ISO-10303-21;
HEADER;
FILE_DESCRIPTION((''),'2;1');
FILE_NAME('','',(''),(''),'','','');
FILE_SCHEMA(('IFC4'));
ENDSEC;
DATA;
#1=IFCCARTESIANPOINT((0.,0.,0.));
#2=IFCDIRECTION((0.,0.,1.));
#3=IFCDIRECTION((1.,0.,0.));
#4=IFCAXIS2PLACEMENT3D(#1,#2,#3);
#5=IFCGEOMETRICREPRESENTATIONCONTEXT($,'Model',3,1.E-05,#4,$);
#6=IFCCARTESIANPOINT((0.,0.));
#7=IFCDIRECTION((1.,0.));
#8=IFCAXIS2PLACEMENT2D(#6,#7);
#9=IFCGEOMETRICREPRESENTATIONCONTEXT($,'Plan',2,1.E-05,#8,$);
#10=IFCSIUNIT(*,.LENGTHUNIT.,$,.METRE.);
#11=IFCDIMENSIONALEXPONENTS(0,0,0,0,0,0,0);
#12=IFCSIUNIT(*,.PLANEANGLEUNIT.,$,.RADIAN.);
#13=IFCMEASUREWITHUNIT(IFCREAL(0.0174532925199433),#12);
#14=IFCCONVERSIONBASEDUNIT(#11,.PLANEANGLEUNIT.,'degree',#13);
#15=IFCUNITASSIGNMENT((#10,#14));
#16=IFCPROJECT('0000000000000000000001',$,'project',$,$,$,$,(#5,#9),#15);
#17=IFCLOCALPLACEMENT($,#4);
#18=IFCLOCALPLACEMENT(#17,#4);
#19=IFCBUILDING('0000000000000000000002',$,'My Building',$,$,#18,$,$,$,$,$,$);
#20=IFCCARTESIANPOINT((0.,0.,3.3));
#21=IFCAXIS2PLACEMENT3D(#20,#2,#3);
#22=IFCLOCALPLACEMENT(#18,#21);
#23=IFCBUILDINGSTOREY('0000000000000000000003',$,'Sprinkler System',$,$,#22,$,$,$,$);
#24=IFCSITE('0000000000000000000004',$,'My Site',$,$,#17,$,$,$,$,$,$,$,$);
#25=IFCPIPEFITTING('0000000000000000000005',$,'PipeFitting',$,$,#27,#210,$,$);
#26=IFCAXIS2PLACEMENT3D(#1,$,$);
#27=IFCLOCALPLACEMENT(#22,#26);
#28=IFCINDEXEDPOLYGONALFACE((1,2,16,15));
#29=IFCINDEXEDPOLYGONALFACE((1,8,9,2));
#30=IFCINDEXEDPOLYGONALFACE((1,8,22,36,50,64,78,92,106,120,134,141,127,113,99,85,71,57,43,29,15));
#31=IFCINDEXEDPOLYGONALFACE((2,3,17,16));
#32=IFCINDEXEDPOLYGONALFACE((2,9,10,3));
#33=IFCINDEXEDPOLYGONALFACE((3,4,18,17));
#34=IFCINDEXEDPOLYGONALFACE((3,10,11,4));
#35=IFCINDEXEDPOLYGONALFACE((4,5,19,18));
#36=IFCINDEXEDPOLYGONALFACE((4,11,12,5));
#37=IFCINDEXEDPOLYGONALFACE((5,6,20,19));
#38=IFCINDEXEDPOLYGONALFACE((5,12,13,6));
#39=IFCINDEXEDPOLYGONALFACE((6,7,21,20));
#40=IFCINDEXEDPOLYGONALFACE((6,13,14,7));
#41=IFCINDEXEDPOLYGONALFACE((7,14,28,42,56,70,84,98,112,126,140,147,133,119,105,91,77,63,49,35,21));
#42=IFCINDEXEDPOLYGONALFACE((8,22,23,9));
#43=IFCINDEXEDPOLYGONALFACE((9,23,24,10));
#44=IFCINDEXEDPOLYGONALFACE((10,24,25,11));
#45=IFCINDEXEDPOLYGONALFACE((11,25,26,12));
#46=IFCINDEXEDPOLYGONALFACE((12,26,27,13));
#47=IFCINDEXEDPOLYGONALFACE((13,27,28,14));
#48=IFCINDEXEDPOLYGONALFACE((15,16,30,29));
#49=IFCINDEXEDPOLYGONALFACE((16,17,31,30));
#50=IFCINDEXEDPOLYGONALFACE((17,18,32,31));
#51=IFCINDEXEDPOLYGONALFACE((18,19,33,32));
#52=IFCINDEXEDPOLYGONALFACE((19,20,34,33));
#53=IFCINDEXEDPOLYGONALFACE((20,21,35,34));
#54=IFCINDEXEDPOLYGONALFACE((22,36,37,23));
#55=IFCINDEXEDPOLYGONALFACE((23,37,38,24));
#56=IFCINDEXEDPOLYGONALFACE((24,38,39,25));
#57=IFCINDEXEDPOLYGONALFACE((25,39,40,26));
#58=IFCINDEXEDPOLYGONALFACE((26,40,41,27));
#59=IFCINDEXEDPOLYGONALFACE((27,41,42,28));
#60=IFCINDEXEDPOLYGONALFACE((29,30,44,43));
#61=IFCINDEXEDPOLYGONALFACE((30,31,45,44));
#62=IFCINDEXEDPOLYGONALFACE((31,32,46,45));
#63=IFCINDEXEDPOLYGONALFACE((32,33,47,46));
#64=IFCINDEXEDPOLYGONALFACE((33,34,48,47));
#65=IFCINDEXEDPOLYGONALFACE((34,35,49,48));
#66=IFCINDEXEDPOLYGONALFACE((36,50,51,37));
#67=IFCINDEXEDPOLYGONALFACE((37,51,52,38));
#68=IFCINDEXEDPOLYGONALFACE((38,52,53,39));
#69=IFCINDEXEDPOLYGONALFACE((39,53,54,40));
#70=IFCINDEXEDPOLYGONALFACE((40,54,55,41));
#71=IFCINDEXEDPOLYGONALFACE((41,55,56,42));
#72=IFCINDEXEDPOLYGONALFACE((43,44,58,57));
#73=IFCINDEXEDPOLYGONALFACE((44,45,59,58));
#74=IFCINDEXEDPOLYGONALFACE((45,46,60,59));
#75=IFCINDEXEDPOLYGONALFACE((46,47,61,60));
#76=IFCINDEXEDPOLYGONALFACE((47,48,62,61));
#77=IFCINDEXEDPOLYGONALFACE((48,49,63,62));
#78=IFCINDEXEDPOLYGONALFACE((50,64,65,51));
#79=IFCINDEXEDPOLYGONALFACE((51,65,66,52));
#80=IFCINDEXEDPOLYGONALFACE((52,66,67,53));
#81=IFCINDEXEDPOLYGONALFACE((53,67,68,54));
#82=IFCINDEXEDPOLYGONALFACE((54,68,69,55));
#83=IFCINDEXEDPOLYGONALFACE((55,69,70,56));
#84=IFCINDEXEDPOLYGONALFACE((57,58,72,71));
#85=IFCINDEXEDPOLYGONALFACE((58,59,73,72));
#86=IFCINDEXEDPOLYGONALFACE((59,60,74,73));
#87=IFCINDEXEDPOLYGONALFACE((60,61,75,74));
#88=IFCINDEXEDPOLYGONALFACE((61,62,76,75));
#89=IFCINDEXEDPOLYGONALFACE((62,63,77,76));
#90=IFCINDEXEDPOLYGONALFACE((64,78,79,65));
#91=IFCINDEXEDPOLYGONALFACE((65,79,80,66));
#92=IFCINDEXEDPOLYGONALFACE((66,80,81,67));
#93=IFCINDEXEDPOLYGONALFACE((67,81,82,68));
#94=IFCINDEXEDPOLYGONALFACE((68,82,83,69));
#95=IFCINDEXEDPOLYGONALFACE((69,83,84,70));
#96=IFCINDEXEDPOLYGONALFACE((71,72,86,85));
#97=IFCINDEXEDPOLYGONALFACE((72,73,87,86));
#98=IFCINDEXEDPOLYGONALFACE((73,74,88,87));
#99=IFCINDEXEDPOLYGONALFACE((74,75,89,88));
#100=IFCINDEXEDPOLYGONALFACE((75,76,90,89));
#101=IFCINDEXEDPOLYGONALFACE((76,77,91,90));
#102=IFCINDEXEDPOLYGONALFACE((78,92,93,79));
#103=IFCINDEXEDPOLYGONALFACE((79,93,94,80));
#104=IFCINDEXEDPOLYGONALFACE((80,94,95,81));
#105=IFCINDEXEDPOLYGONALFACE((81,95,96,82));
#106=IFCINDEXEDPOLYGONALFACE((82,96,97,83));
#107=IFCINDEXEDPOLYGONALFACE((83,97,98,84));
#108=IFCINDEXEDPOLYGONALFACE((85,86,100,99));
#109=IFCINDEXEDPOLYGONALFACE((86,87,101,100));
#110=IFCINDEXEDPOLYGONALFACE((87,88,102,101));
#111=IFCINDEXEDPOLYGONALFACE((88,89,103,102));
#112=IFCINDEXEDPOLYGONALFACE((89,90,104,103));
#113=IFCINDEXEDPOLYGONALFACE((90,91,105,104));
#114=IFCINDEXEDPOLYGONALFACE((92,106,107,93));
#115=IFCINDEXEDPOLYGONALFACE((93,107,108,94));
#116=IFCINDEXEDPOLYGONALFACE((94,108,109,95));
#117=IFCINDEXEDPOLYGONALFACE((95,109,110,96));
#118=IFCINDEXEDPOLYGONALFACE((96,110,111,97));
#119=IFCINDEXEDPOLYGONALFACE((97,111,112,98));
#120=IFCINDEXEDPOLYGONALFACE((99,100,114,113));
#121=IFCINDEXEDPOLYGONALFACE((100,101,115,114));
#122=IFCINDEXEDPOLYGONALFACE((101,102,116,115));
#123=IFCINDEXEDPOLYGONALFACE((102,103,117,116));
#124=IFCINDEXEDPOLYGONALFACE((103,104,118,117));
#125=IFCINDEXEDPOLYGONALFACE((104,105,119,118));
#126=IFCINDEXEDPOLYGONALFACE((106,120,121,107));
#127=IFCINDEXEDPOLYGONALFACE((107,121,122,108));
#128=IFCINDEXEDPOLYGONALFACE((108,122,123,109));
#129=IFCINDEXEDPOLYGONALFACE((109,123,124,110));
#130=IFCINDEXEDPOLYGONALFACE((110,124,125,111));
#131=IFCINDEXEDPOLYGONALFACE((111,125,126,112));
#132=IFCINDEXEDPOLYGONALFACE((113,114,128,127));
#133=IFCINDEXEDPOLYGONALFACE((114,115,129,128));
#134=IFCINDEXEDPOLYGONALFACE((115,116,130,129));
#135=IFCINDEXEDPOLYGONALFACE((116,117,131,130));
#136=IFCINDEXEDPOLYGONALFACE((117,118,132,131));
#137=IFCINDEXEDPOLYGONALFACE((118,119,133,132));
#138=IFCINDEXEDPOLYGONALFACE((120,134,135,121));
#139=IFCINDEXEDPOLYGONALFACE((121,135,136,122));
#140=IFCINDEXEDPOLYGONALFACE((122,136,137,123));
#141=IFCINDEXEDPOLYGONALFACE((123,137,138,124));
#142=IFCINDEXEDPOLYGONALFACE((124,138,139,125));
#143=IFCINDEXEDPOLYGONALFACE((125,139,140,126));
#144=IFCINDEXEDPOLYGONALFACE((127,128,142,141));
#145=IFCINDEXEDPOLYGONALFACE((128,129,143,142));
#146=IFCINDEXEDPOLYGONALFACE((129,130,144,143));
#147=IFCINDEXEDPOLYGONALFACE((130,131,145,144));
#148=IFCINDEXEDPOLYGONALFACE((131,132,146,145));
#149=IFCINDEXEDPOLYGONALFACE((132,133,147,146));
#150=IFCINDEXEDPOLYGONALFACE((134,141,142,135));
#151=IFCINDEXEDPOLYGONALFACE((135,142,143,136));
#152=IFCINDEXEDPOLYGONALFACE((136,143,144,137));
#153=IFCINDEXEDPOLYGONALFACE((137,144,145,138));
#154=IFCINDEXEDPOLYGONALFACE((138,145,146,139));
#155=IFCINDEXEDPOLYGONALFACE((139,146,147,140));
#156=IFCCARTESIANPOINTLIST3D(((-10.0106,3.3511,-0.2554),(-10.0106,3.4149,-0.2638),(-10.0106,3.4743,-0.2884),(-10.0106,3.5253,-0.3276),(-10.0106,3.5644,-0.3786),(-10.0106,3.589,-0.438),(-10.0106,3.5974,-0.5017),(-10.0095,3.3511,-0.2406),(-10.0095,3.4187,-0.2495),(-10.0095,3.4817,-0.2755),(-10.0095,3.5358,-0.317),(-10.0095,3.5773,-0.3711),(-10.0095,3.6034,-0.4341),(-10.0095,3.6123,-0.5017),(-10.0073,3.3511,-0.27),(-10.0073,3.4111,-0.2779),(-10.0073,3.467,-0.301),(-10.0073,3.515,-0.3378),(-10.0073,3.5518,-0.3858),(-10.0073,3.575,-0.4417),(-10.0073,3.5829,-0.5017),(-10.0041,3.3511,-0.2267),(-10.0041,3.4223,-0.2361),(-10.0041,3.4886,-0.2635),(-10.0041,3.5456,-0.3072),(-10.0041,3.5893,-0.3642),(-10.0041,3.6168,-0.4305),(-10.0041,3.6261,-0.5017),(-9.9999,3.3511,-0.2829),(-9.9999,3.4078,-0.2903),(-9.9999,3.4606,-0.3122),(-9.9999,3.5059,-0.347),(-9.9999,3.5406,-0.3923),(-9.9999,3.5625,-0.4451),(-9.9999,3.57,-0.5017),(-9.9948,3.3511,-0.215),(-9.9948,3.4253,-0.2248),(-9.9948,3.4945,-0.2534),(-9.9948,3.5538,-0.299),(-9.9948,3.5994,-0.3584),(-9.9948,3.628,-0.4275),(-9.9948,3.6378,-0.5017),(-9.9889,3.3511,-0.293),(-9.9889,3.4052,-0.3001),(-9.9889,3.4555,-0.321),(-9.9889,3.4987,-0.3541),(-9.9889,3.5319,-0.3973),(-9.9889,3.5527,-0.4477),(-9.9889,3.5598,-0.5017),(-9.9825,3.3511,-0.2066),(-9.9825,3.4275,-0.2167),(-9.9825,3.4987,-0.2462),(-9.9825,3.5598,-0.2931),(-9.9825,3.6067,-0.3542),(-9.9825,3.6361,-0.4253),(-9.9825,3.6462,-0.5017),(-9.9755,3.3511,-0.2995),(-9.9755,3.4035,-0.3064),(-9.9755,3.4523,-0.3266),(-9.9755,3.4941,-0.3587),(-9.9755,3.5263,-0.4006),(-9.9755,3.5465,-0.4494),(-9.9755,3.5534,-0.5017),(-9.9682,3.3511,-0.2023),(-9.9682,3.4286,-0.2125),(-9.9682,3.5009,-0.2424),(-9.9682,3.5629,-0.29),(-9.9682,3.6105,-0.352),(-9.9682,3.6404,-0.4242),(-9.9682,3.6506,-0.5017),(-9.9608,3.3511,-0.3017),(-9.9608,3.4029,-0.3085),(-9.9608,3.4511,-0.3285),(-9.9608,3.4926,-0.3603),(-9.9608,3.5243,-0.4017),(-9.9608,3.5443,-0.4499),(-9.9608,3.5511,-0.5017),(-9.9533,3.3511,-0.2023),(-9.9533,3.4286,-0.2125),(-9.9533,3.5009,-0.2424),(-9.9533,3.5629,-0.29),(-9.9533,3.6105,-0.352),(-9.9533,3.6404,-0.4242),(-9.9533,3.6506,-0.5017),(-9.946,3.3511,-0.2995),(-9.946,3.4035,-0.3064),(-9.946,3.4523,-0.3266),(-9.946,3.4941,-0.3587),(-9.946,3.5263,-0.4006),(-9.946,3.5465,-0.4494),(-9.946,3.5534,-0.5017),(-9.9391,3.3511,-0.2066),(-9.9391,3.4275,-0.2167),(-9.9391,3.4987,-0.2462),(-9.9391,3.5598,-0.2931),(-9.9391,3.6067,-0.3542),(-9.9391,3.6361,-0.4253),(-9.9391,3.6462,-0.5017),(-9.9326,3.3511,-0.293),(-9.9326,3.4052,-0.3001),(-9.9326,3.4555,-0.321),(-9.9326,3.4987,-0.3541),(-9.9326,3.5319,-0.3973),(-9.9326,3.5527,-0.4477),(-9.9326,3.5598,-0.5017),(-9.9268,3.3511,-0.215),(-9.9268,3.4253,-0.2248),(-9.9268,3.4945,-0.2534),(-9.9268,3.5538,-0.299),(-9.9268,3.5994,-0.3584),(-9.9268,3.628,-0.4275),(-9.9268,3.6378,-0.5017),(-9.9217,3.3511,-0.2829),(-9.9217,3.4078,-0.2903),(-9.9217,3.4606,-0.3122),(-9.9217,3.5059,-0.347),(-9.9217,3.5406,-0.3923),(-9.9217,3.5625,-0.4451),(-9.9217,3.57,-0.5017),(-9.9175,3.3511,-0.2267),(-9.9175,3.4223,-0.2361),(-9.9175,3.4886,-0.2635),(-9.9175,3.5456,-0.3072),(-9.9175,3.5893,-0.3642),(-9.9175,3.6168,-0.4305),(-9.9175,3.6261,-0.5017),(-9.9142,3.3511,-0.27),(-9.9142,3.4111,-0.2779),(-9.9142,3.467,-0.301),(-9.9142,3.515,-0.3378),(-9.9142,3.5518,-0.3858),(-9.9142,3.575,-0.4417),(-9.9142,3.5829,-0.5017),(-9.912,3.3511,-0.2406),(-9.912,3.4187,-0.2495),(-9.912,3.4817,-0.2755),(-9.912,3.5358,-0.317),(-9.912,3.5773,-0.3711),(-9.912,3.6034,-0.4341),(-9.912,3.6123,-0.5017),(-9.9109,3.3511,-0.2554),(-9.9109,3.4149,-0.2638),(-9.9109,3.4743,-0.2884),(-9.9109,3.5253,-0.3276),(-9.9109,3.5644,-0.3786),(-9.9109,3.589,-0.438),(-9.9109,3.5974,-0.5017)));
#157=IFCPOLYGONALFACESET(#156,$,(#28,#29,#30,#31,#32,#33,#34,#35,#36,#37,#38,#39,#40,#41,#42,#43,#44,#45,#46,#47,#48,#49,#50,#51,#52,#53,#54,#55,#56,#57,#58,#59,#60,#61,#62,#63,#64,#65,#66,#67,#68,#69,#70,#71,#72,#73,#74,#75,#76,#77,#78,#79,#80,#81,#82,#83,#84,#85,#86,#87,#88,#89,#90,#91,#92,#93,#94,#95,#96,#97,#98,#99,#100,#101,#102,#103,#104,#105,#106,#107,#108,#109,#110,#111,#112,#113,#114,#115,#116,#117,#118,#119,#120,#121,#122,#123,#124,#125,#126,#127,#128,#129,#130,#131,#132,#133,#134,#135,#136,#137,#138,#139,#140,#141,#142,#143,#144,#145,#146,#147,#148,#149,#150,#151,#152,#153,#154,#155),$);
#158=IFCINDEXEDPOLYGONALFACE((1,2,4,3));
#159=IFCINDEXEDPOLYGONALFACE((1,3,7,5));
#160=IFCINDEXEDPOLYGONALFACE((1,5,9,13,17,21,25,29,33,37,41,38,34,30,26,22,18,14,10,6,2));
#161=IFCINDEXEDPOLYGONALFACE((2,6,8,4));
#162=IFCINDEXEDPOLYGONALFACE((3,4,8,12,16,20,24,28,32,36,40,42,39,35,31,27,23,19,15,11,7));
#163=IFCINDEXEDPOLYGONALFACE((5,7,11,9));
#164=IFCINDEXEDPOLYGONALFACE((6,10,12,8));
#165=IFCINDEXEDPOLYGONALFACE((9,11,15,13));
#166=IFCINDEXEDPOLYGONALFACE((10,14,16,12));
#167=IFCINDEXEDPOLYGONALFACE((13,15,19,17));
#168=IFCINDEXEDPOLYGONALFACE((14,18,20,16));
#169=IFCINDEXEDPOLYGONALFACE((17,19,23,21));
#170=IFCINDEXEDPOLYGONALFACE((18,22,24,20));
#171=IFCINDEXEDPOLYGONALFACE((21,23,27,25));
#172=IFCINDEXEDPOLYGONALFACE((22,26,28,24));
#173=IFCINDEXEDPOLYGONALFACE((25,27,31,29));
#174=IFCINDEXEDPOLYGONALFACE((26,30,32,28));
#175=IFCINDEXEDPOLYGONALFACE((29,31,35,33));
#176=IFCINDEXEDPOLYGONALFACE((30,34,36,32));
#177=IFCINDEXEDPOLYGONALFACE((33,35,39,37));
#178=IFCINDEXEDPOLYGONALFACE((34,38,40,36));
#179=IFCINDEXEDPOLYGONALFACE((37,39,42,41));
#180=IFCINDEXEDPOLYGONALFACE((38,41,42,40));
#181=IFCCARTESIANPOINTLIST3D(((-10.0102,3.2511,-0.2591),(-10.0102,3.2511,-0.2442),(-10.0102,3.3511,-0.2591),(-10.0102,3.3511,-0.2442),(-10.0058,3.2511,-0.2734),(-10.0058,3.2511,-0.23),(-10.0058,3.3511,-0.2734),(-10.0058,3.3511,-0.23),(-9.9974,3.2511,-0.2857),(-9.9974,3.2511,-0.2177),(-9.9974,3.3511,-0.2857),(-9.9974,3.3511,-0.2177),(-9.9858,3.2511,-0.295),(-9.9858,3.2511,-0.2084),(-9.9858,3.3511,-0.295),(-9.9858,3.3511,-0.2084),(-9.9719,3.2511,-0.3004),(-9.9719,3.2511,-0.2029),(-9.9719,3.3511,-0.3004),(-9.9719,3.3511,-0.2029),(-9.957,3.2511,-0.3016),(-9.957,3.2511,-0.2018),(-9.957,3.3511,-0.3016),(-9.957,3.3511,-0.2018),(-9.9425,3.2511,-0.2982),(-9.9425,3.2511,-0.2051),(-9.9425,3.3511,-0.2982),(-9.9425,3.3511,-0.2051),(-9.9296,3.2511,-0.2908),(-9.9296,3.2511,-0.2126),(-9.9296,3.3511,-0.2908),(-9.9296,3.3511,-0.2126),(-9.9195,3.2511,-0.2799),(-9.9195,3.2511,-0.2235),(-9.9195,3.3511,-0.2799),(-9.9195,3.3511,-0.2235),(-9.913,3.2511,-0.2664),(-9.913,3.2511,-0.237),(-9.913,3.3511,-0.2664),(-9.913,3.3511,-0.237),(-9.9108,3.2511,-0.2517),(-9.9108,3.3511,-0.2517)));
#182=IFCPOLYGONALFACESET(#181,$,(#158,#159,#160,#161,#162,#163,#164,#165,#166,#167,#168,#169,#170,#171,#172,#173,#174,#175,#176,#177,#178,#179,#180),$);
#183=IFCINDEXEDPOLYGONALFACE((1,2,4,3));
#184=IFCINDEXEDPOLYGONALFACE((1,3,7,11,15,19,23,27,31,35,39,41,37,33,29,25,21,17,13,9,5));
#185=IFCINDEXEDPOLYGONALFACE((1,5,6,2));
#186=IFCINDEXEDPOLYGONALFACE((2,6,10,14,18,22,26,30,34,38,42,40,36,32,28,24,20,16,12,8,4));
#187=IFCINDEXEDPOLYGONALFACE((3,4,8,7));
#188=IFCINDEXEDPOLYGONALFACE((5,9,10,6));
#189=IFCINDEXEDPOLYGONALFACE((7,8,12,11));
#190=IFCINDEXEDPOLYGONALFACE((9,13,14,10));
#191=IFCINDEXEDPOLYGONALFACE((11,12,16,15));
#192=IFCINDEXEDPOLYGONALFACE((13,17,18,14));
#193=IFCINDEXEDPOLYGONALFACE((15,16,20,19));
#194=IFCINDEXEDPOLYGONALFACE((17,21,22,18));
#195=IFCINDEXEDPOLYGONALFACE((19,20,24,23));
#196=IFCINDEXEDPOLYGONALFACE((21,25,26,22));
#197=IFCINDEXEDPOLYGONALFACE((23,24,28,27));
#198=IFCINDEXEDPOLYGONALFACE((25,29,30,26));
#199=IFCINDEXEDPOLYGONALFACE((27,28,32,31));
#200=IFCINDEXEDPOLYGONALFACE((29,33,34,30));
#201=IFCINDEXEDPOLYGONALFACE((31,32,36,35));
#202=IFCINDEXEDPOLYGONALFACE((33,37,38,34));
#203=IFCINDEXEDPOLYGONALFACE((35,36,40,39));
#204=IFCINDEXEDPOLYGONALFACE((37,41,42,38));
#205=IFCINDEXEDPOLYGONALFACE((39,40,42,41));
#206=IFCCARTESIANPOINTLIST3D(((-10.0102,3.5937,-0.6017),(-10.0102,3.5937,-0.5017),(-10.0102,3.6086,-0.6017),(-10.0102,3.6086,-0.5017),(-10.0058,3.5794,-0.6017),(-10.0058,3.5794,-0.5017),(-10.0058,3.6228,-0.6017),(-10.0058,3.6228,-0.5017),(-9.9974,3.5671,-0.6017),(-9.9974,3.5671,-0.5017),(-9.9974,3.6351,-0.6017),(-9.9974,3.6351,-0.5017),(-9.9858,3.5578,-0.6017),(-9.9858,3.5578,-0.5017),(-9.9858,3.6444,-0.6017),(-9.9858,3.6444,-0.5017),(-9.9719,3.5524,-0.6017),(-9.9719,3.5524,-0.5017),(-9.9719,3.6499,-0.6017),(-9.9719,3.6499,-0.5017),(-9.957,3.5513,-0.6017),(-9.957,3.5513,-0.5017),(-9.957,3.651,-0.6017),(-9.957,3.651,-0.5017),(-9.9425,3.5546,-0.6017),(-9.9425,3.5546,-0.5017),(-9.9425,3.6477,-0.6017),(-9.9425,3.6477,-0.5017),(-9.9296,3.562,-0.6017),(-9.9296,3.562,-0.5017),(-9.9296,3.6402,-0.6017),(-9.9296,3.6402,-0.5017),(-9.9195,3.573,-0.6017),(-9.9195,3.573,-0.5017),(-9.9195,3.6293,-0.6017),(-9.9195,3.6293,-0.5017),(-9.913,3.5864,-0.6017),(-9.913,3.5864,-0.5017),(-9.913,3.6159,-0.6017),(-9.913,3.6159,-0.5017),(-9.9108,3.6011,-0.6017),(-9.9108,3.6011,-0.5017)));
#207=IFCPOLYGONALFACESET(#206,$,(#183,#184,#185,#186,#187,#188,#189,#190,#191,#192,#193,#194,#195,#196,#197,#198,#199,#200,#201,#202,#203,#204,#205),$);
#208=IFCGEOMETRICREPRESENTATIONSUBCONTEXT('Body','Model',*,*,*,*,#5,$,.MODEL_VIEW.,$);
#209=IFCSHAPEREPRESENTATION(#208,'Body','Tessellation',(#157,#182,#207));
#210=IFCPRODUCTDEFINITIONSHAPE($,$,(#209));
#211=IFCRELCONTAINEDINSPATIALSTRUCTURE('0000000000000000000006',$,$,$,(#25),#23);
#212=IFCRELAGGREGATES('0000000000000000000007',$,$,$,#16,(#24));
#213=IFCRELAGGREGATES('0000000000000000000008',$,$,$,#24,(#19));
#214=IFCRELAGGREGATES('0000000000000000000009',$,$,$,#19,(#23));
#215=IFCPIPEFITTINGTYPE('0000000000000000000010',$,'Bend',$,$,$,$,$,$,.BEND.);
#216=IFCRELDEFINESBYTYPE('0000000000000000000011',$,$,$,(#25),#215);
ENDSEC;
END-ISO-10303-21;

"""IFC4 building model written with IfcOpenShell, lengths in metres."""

from ifc_helpers import new_model, entity, si_unit, converted_unit, frame, origin_with_axes, origin_2d_with_axis, place, context, subcontext, project, spatial, circle, extrude, source, transform, mapped, type_object, type_shapes, element, save


model = new_model("IFC4")

# Units and contexts
model_context = context("Model", 3, precision=1e-05, world=origin_with_axes())
plan_context = context("Plan", 2, precision=1e-05, world=origin_2d_with_axis())
body_context = subcontext(model_context, "Body", "Model", "MODEL_VIEW")
ifc_project = project(units=[si_unit("LENGTHUNIT", "METRE"), converted_unit("PLANEANGLEUNIT", "degree", entity("IfcReal", 0.0174532925199433), si_unit("PLANEANGLEUNIT", "RADIAN"), dimensions=[0, 0, 0, 0, 0, 0, 0])], contexts=[model_context, plan_context])

# Site, building, storey
site_placement = place(None, origin_with_axes())
site = spatial("IfcSite", under=ifc_project, at=site_placement, Name="My Site")
building_placement = place(site_placement, origin_with_axes())
building = spatial("IfcBuilding", under=site, at=building_placement, Name="My Building")
storey_placement = place(building_placement, frame((0.0, 0.0, 3.3), z_axis=(0.0, 0.0, 1.0), x_axis=(1.0, 0.0, 0.0)))
storey = spatial("IfcBuildingStorey", under=building, at=storey_placement, Name="Sprinkler System")

# Pipe fitting
pipe_fitting_type_1 = type_object("IfcPipeFittingType", Name="Bend", PredefinedType="BEND")
shared_shape_1 = source(origin_with_axes(), body_context, "Body", "SolidModel", [
    entity("IfcSweptDiskSolid", entity("IfcIndexedPolyCurve", entity("IfcCartesianPointList3D", [[0.0, 0.0, -0.1], [0.0, -0.0732, -0.2768], [0.0, -0.25, -0.35]]), [entity("IfcArcIndex", [1, 2, 3])]), 0.05),
    extrude(circle(Radius=0.05), origin_with_axes(), (0.0, 0.0, -1.0), 0.1),
    extrude(circle(Radius=0.05), frame((0.0, -0.25, -0.35), z_axis=(0.0, -1.0, 0.000012), x_axis=(1.0, 0.0, 0.0)), (0.0, 0.0, 1.0), 0.1),
])
type_shapes(pipe_fitting_type_1, [shared_shape_1])
for number, where, z_axis, x_axis, name in (
    (1, (-9.9608, 3.2511, -0.2517), (-0.000001, -1.0, -0.000012), (1.0, -0.000001, 0.0), "PipeFitting"),
):
    element("IfcPipeFitting", number, at=place(storey_placement, frame(where, z_axis=z_axis, x_axis=x_axis)), inside=storey, type_object=pipe_fitting_type_1, Name=name, context=body_context, shape_type="MappedRepresentation", body=[
        mapped(shared_shape_1, transform((0.0, 0.0, 0.0), x_axis=(1.0, 0.0, 0.0), y_axis=(0.0, 1.0, 0.0), z_axis=(0.0, 0.0, 1.0), scale=1.0)),
    ])

save(model, "model.ifc")
